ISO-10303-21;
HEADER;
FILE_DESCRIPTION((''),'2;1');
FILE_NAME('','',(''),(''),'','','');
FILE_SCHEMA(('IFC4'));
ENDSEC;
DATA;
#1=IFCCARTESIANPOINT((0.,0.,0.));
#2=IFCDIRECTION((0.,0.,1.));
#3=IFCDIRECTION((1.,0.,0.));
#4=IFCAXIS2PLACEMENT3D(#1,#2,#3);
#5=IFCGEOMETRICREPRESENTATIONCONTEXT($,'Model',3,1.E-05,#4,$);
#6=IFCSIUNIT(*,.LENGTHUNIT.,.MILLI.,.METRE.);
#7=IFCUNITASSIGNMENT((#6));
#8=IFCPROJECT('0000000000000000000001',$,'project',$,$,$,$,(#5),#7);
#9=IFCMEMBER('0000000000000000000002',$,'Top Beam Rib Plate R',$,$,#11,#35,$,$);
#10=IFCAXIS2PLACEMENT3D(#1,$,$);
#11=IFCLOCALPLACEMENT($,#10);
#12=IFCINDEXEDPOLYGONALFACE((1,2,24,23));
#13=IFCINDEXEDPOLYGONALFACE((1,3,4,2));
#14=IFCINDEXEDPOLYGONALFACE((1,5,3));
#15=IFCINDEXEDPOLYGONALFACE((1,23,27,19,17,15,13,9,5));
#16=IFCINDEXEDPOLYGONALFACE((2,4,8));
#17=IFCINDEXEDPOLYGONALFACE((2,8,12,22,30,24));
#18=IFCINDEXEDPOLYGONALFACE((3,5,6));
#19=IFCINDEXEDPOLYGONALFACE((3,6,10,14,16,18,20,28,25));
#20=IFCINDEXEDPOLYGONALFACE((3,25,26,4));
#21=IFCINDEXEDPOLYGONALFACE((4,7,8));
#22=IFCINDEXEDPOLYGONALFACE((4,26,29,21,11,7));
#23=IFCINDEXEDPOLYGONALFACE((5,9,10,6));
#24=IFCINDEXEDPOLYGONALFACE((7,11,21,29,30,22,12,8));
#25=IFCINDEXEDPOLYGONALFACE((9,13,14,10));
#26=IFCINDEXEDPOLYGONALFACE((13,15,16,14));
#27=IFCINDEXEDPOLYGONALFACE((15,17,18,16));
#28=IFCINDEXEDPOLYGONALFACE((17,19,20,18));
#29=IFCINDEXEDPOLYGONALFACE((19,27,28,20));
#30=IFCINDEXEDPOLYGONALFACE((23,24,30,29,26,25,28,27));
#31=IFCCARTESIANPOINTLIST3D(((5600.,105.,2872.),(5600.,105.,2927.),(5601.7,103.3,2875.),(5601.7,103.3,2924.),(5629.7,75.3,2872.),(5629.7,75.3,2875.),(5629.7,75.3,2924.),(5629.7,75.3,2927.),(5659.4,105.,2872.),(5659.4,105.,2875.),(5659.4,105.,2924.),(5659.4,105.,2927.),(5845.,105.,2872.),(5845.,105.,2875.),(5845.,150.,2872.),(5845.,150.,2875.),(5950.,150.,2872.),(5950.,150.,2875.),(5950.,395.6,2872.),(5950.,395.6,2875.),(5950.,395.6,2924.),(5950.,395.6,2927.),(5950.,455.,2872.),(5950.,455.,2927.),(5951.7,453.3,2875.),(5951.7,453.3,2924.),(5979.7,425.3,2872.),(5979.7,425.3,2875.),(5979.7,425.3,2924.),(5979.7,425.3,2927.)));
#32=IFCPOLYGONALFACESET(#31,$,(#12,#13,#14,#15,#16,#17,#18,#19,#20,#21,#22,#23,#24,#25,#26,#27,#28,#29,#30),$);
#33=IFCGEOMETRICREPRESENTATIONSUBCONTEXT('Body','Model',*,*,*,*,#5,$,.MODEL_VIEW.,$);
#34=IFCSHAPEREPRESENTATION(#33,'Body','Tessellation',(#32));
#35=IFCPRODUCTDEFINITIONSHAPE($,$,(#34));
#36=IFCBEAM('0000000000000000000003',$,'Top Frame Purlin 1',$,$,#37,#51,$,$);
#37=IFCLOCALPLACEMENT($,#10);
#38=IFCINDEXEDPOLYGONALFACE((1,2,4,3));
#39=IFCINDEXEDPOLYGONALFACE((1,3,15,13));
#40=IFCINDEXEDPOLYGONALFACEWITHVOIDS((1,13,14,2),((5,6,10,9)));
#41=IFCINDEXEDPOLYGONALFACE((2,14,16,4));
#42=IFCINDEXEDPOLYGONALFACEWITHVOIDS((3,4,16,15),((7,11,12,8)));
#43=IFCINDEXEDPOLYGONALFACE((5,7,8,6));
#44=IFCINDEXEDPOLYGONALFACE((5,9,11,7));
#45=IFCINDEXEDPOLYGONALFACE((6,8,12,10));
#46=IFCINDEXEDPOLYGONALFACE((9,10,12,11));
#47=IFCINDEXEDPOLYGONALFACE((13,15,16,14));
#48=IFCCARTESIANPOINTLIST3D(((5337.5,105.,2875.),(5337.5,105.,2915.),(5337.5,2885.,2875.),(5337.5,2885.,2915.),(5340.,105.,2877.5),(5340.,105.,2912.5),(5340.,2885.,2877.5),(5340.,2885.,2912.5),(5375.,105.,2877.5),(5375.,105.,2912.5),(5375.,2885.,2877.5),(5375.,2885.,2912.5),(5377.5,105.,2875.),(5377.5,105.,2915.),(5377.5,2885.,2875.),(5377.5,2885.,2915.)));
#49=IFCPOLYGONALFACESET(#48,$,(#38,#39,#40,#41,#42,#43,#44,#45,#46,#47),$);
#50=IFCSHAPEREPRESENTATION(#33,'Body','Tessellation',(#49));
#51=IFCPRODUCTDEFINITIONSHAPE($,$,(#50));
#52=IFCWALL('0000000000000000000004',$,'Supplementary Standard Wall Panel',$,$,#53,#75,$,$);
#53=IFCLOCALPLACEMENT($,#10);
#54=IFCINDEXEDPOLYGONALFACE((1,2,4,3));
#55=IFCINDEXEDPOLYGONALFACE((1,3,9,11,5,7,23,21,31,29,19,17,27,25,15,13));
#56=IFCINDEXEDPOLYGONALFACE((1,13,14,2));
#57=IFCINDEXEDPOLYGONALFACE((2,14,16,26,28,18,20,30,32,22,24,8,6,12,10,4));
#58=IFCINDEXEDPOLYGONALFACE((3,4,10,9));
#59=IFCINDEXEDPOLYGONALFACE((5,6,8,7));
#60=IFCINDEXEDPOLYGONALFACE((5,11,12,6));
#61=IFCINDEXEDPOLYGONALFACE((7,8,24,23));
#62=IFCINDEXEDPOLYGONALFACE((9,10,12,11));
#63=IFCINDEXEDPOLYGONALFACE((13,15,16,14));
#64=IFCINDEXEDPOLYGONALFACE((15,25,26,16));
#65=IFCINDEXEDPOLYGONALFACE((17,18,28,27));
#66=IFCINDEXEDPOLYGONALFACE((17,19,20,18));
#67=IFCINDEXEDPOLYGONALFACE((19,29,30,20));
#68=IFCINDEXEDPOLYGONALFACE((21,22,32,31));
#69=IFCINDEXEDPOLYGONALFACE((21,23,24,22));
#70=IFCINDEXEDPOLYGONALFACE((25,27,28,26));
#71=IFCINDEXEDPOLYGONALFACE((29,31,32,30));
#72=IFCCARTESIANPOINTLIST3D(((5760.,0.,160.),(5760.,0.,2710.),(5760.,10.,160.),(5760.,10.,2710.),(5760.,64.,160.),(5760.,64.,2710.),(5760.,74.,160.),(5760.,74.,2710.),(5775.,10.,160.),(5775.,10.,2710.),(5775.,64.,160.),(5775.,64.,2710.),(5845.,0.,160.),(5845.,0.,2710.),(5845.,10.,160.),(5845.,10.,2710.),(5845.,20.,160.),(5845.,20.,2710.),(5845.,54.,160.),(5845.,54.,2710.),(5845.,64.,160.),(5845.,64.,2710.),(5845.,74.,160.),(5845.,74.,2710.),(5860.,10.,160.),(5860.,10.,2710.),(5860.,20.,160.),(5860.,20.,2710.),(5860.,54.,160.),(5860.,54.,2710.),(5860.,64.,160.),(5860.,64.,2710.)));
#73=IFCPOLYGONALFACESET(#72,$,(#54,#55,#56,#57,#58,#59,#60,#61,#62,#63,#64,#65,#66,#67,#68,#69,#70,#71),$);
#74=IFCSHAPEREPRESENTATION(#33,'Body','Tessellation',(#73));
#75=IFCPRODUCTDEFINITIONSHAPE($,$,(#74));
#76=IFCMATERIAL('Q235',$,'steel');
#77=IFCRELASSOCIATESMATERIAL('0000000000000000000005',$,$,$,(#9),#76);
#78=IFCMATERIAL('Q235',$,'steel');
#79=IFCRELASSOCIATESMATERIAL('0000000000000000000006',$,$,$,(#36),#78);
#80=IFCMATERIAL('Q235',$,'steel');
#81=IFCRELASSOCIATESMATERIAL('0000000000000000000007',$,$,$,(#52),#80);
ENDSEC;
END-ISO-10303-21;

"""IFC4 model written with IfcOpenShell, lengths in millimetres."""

from ifc_helpers import new_model, si_unit, frame, origin_with_axes, place, context, subcontext, project, line, indexed_curve, outline, extrude, material, element, save


model = new_model("IFC4")

# Units and contexts
model_context = context("Model", 3, precision=1e-05, world=origin_with_axes())
body_context = subcontext(model_context, "Body", "Model", "MODEL_VIEW")
ifc_project = project(units=[si_unit("LENGTHUNIT", "METRE", prefix="MILLI")], contexts=[model_context])

# Member, openings
ifc_material_1 = material(Name="Q235", Category="steel")
member_1_placement = place(None, frame((5845.0, 150.0, 2872.0), z_axis=(0.0, 0.0, 1.0), x_axis=(-1.0, 0.0, 0.0)))
member_1 = element("IfcMember", 1, at=member_1_placement, material=ifc_material_1, Name="Top Beam Rib Plate R", context=body_context, shape_type="SweptSolid", body=[
    extrude(outline(indexed_curve([(0.0, 0.0), (0.0, 45.0), (185.6, 45.0), (215.3, 74.7), (245.0, 45.0), (-105.0, -305.0), (-134.7, -275.3), (-105.0, -245.6), (-105.0, 0.0), (0.0, 0.0)], segments=[line(1, 2, 3, 4, 5, 6, 7, 8, 9, 10, 1)])), origin_with_axes(), (0.0, 0.0, 1.0), 55.0),
])
opening_1_placement = place(member_1_placement, frame((0.0, 0.0, 3.0), z_axis=(0.0, 0.0, 1.0), x_axis=(1.0, 0.0, 0.0)))
element("IfcOpeningElement", 2, at=opening_1_placement, cuts=member_1, context=body_context, shape_type="SweptSolid", body=[
    extrude(outline(indexed_curve([(0.0, 0.0), (0.0, 45.0), (185.6, 45.0), (-105.0, -245.6), (-105.0, 0.0), (0.0, 0.0)], segments=[line(1, 2, 3, 4, 5, 6, 1)])), origin_with_axes(), (0.0, 0.0, 1.0), 55.0),
])
opening_2_placement = place(member_1_placement, frame((0.0, 0.0, 3.0), z_axis=(0.0, 0.0, 1.0), x_axis=(1.0, 0.0, 0.0)))
element("IfcOpeningElement", 3, at=opening_2_placement, cuts=member_1, context=body_context, shape_type="SweptSolid", body=[
    extrude(outline(indexed_curve([(215.3, 74.7), (243.3, 46.7), (-106.7, -303.3), (-134.7, -275.3)], segments=[line(1, 2, 3, 4, 1)])), origin_with_axes(), (0.0, 0.0, 1.0), 49.0),
])

# Beam, opening
ifc_material_2 = material(Name="Q235", Category="steel")
beam_1_placement = place(None, frame((5337.5, 105.0, 2875.0), z_axis=(0.0, 1.0, 0.0), x_axis=(1.0, 0.0, 0.0)))
beam_1 = element("IfcBeam", 4, at=beam_1_placement, material=ifc_material_2, Name="Top Frame Purlin 1", context=body_context, shape_type="SweptSolid", body=[
    extrude(outline(indexed_curve([(0.0, 0.0), (0.0, -40.0), (40.0, -40.0), (40.0, 0.0), (0.0, 0.0)], segments=[line(1, 2, 3, 4, 5, 1)])), origin_with_axes(), (0.0, 0.0, 1.0), 2780.0),
])
opening_3_placement = place(beam_1_placement, frame((2.5, -2.5, 0.0), z_axis=(0.0, 0.0, 1.0), x_axis=(1.0, 0.0, 0.0)))
element("IfcOpeningElement", 5, at=opening_3_placement, cuts=beam_1, context=body_context, shape_type="SweptSolid", body=[
    extrude(outline(indexed_curve([(0.0, 0.0), (0.0, -35.0), (35.0, -35.0), (35.0, 0.0)], segments=[line(1, 2, 3, 4, 1)])), origin_with_axes(), (0.0, 0.0, 1.0), 2780.0),
])

# Wall
ifc_material_3 = material(Name="Q235", Category="steel")
wall_placement = place(None, frame((5760.0, 0.0, 160.0), z_axis=(0.0, 0.0, 1.0), x_axis=(1.0, 0.0, 0.0)))
element("IfcWall", 6, at=wall_placement, material=ifc_material_3, Name="Supplementary Standard Wall Panel", context=body_context, shape_type="SweptSolid", body=[
    extrude(outline(indexed_curve([(0.0, 0.0), (0.0, 10.0), (15.0, 10.0), (15.0, 64.0), (0.0, 64.0), (0.0, 74.0), (85.0, 74.0), (85.0, 64.0), (100.0, 64.0), (100.0, 54.0), (85.0, 54.0), (85.0, 20.0), (100.0, 20.0), (100.0, 10.0), (85.0, 10.0), (85.0, 0.0), (0.0, 0.0)], segments=[line(1, 2, 3, 4, 5, 6, 7, 8, 9, 10, 11, 12, 13, 14, 15, 16, 17, 1)])), origin_with_axes(), (0.0, 0.0, 1.0), 2550.0),
])

save(model, "model.ifc")
